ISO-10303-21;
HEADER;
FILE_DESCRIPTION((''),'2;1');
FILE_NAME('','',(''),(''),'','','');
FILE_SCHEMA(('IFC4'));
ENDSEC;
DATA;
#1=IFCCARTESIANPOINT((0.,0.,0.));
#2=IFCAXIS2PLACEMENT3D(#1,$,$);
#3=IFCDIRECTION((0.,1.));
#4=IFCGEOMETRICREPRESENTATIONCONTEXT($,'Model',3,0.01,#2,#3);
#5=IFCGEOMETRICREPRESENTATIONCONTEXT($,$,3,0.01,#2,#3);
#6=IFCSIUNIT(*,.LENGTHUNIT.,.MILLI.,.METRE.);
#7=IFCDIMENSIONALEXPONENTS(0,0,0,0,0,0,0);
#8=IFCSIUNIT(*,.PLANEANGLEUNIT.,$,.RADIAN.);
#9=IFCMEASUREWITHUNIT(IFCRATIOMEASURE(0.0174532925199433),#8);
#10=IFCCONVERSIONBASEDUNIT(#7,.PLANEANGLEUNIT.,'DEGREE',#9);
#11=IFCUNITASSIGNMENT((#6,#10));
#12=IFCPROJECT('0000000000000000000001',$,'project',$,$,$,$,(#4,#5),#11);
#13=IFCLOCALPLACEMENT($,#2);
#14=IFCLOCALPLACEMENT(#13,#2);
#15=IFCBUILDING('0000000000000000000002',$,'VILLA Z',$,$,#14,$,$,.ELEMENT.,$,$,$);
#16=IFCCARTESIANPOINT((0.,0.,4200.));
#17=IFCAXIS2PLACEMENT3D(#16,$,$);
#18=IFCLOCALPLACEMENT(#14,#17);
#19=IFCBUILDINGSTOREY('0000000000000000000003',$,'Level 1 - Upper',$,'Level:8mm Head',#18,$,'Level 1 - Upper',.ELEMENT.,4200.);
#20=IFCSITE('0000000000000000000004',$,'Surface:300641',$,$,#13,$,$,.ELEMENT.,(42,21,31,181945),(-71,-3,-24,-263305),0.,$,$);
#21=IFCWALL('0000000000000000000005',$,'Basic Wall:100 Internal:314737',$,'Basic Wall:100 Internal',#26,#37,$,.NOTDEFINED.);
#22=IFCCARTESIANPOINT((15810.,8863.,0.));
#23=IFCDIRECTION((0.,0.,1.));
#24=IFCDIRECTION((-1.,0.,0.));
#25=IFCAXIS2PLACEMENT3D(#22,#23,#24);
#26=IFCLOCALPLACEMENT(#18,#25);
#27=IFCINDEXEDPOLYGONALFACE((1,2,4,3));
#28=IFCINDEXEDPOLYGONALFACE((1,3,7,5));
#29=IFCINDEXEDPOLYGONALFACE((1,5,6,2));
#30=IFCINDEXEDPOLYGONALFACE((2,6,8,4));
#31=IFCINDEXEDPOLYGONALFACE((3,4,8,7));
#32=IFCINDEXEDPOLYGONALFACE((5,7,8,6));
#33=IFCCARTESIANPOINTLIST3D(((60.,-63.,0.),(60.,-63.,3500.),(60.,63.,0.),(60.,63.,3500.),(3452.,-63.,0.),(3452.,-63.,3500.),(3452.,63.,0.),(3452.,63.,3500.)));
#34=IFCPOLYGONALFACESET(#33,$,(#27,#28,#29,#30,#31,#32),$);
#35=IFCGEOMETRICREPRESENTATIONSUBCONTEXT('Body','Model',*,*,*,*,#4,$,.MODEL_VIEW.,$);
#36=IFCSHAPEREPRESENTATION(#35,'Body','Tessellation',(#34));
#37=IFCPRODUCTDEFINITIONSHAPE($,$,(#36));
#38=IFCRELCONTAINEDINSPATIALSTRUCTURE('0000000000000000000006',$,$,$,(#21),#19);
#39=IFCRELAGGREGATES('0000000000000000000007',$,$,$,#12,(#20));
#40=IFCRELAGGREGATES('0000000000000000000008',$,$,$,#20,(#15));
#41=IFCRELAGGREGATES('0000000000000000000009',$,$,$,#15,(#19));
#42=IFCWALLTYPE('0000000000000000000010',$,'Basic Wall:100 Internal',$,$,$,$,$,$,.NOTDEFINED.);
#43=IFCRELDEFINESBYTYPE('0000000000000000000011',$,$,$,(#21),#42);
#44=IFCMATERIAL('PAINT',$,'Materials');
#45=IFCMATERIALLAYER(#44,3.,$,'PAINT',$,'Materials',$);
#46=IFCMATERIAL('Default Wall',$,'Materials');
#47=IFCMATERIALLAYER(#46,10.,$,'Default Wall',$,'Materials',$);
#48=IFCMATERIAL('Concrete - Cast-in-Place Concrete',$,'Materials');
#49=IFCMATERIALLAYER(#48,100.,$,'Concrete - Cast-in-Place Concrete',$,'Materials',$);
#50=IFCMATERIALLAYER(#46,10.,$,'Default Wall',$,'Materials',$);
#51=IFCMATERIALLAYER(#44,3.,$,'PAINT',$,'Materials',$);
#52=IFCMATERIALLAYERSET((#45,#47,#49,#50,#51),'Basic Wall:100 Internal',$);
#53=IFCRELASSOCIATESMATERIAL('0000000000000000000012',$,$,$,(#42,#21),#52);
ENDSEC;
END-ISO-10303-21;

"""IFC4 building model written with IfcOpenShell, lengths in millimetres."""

from ifc_helpers import new_model, entity, si_unit, converted_unit, direction, frame, frame_2d, origin, place, context, subcontext, project, spatial, rectangle, extrude, clip, halfspace, material, layer, layer_set, layer_usage, type_object, element, save


model = new_model("IFC4")

# Units and contexts
model_context = context("Model", 3, precision=0.01, world=origin(), true_north=direction((0.0, 1.0)))
context_of_model = context(None, 3, precision=0.01, world=origin(), true_north=direction((0.0, 1.0)))
body_context = subcontext(model_context, "Body", "Model", "MODEL_VIEW")
ifc_project = project(units=[si_unit("LENGTHUNIT", "METRE", prefix="MILLI"), converted_unit("PLANEANGLEUNIT", "DEGREE", entity("IfcRatioMeasure", 0.0174532925199433), si_unit("PLANEANGLEUNIT", "RADIAN"), dimensions=[0, 0, 0, 0, 0, 0, 0])], contexts=[model_context, context_of_model])

# Site, building, storey
site_placement = place(None, origin())
site = spatial("IfcSite", under=ifc_project, at=site_placement, Name="Surface:300641", CompositionType="ELEMENT", RefLatitude=(42, 21, 31, 181945), RefLongitude=(-71, -3, -24, -263305), RefElevation=0.0)
building_placement = place(site_placement, origin())
building = spatial("IfcBuilding", under=site, at=building_placement, Name="VILLA Z", CompositionType="ELEMENT")
storey_placement = place(building_placement, frame((0.0, 0.0, 4200.0)))
storey = spatial("IfcBuildingStorey", under=building, at=storey_placement, Name="Level 1 - Upper", ObjectType="Level:8mm Head", LongName="Level 1 - Upper", CompositionType="ELEMENT", Elevation=4200.0)

# Shared definitions
ifc_material_1 = material(Name="PAINT", Category="Materials")
ifc_material_2 = material(Name="Concrete - Cast-in-Place Concrete", Category="Materials")
ifc_material_3 = material(Name="Default Wall", Category="Materials")

# Wall
ifc_layer_1 = layer(ifc_material_1, 3.0, Name="PAINT", Category="Materials")
ifc_layer_2 = layer(ifc_material_3, 10.0, Name="Default Wall", Category="Materials")
ifc_layer_3 = layer(ifc_material_2, 100.0, Name="Concrete - Cast-in-Place Concrete", Category="Materials")
ifc_layer_4 = layer(ifc_material_3, 10.0, Name="Default Wall", Category="Materials")
ifc_layer_5 = layer(ifc_material_1, 3.0, Name="PAINT", Category="Materials")
ifc_layer_set_1 = layer_set([ifc_layer_1, ifc_layer_2, ifc_layer_3, ifc_layer_4, ifc_layer_5], Name="Basic Wall:100 Internal")
ifc_layer_usage_1 = layer_usage(ifc_layer_set_1, "AXIS2", "NEGATIVE", 63.0)
wall_type_1 = type_object("IfcWallType", Name="Basic Wall:100 Internal", PredefinedType="NOTDEFINED", material=ifc_layer_set_1)
wall_1_placement = place(storey_placement, frame((15810.0, 8863.0, 0.0), z_axis=(0.0, 0.0, 1.0), x_axis=(-1.0, 0.0, 0.0)))
element("IfcWall", 1, at=wall_1_placement, inside=storey, type_object=wall_type_1, material=ifc_layer_usage_1, Name="Basic Wall:100 Internal:314737", ObjectType="Basic Wall:100 Internal", PredefinedType="NOTDEFINED", context=body_context, shape_type="Clipping", body=[
    clip(extrude(rectangle(XDim=3392.0, YDim=126.0, at=frame_2d((1756.0, 0.0), x_axis=(-1.0, 0.0))), origin(), (0.0, 0.0, 1.0), 3500.0), halfspace(origin(), True)),
])

save(model, "model.ifc")
